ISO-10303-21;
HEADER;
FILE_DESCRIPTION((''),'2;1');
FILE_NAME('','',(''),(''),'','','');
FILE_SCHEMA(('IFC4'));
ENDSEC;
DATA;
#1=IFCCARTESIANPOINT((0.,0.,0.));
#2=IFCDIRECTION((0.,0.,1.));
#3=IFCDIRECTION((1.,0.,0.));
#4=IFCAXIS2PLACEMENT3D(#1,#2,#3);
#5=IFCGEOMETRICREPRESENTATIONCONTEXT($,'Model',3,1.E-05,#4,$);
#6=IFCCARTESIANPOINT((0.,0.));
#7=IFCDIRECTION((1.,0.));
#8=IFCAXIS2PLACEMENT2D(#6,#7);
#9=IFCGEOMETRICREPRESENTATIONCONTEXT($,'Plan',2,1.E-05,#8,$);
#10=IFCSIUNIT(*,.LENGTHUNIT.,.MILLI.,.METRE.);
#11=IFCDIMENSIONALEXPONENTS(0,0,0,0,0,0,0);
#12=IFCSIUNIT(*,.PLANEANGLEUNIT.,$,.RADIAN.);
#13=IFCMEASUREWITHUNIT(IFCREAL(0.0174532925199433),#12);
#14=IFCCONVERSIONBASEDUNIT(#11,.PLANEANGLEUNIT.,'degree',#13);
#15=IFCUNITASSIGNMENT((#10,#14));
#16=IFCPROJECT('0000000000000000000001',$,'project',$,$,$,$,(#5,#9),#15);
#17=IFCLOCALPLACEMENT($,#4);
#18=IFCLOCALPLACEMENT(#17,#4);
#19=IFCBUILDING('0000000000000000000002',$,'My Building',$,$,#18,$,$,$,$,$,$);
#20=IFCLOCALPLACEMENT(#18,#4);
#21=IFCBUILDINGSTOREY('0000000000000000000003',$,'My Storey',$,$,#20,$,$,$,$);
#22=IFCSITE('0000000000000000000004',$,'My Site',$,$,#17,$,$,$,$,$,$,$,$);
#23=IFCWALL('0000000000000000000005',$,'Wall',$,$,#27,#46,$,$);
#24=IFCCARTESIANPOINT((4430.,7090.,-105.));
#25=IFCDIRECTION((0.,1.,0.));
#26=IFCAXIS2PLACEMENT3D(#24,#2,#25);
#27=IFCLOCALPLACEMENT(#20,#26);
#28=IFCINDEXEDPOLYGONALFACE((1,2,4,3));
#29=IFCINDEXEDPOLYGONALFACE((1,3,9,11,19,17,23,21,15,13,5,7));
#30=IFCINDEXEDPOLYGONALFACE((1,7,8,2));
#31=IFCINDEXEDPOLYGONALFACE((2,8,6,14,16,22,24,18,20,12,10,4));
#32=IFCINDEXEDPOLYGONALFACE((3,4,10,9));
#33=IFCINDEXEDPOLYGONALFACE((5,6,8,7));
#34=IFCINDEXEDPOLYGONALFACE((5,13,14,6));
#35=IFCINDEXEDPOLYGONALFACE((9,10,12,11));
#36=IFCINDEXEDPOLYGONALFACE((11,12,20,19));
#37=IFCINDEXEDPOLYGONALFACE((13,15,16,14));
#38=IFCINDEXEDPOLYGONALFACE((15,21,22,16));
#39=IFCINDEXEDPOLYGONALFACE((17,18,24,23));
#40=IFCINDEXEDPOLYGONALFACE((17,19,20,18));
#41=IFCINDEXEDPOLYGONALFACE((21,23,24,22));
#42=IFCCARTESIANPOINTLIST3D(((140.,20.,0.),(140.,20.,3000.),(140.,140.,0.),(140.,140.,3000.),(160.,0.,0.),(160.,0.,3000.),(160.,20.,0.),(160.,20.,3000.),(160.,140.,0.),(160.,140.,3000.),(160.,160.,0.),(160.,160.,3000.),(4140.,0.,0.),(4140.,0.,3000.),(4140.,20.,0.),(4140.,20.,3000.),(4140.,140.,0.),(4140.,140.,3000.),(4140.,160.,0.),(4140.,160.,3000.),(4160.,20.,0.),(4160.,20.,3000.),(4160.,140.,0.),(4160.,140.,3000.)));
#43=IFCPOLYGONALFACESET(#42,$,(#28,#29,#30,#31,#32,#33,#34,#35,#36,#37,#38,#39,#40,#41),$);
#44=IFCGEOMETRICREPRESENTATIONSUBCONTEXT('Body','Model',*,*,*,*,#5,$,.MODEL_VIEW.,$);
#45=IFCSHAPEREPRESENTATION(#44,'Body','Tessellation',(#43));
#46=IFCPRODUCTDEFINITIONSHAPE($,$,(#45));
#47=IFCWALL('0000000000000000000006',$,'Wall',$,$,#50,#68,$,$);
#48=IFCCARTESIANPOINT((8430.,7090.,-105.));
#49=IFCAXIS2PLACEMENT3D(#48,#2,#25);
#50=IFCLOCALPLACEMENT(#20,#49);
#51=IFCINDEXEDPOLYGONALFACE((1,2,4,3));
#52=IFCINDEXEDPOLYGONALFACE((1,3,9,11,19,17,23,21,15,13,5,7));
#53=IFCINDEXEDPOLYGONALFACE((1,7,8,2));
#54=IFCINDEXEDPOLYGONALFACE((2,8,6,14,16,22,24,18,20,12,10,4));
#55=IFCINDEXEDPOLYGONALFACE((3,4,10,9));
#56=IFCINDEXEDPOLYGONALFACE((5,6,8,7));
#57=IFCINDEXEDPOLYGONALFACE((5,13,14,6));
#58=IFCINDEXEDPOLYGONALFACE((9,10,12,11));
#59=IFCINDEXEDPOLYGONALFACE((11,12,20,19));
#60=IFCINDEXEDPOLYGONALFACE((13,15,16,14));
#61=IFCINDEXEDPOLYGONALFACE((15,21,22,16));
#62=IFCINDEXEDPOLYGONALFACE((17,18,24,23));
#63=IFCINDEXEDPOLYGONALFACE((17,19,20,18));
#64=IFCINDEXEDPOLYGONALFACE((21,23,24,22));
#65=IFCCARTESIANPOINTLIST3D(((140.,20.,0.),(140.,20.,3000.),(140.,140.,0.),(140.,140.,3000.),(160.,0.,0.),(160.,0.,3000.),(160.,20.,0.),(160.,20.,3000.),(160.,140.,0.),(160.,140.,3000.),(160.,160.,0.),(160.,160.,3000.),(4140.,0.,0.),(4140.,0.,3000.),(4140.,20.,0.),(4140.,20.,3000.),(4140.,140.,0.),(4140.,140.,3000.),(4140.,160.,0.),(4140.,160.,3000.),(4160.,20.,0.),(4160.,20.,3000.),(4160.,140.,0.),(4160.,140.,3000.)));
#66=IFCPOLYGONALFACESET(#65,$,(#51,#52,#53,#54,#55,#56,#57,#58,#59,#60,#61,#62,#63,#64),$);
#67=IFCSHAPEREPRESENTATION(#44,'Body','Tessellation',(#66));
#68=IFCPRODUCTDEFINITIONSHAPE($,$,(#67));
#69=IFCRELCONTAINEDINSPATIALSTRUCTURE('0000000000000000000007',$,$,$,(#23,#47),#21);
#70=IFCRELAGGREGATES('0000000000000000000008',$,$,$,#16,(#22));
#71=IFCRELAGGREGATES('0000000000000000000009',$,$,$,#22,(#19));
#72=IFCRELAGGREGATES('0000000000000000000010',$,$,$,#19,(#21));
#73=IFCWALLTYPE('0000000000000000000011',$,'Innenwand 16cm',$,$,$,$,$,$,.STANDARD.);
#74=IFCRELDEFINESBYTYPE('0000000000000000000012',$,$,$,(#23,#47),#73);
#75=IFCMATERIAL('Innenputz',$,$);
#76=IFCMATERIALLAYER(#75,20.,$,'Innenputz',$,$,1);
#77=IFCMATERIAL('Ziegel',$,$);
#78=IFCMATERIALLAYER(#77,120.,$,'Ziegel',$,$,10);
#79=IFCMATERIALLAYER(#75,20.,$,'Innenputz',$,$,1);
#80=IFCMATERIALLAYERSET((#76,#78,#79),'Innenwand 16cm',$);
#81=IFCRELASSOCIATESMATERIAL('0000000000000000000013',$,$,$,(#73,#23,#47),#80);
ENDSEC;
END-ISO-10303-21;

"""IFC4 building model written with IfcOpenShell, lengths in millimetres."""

from ifc_helpers import new_model, entity, si_unit, converted_unit, frame, origin_with_axes, origin_2d_with_axis, place, context, subcontext, project, spatial, line, indexed_curve, outline, extrude, material, layer, layer_set, layer_usage, type_object, element, save


model = new_model("IFC4")

# Units and contexts
model_context = context("Model", 3, precision=1e-05, world=origin_with_axes())
plan_context = context("Plan", 2, precision=1e-05, world=origin_2d_with_axis())
body_context = subcontext(model_context, "Body", "Model", "MODEL_VIEW")
ifc_project = project(units=[si_unit("LENGTHUNIT", "METRE", prefix="MILLI"), converted_unit("PLANEANGLEUNIT", "degree", entity("IfcReal", 0.0174532925199433), si_unit("PLANEANGLEUNIT", "RADIAN"), dimensions=[0, 0, 0, 0, 0, 0, 0])], contexts=[model_context, plan_context])

# Site, building, storey
site_placement = place(None, origin_with_axes())
site = spatial("IfcSite", under=ifc_project, at=site_placement, Name="My Site")
building_placement = place(site_placement, origin_with_axes())
building = spatial("IfcBuilding", under=site, at=building_placement, Name="My Building")
storey_placement = place(building_placement, origin_with_axes())
storey = spatial("IfcBuildingStorey", under=building, at=storey_placement, Name="My Storey")

# Walls
ifc_material_1 = material(Name="Innenputz")
ifc_material_2 = material(Name="Ziegel")
ifc_layer_1 = layer(ifc_material_1, 20.0, Name="Innenputz", Priority=1)
ifc_layer_2 = layer(ifc_material_2, 120.0, Name="Ziegel", Priority=10)
ifc_layer_3 = layer(ifc_material_1, 20.0, Name="Innenputz", Priority=1)
ifc_layer_set_1 = layer_set([ifc_layer_1, ifc_layer_2, ifc_layer_3], Name="Innenwand 16cm")
wall_type_1 = type_object("IfcWallType", Name="Innenwand 16cm", PredefinedType="STANDARD", material=ifc_layer_set_1)
ifc_layer_usage_1 = layer_usage(ifc_layer_set_1, "AXIS2", "POSITIVE", 0.0)
wall_1_placement = place(storey_placement, frame((4430.0, 7090.0, -105.0), z_axis=(0.0, 0.0, 1.0), x_axis=(0.0, 1.0, 0.0)))
element("IfcWall", 1, at=wall_1_placement, inside=storey, type_object=wall_type_1, material=ifc_layer_usage_1, Name="Wall", context=body_context, shape_type="SweptSolid", body=[
    extrude(outline(indexed_curve([(160.0, 0.0), (160.0, 20.0), (140.0, 20.0), (140.0, 140.0), (160.0, 140.0), (160.0, 160.0), (4140.0, 160.0), (4140.0, 140.0), (4160.0, 140.0), (4160.0, 20.0), (4140.0, 20.0), (4140.0, 0.0)], segments=[line(1, 2, 3, 4, 5, 6, 7, 8, 9, 10, 11, 12, 1)])), origin_with_axes(), (0.0, 0.0, 1.0), 3000.0),
])
ifc_layer_usage_2 = layer_usage(ifc_layer_set_1, "AXIS2", "POSITIVE", 0.0)
wall_2_placement = place(storey_placement, frame((8430.0, 7090.0, -105.0), z_axis=(0.0, 0.0, 1.0), x_axis=(0.0, 1.0, 0.0)))
element("IfcWall", 2, at=wall_2_placement, inside=storey, type_object=wall_type_1, material=ifc_layer_usage_2, Name="Wall", context=body_context, shape_type="SweptSolid", body=[
    extrude(outline(indexed_curve([(160.0, 0.0), (160.0, 20.0), (140.0, 20.0), (140.0, 140.0), (160.0, 140.0), (160.0, 160.0), (4140.0, 160.0), (4140.0, 140.0), (4160.0, 140.0), (4160.0, 20.0), (4140.0, 20.0), (4140.0, 0.0)], segments=[line(1, 2, 3, 4, 5, 6, 7, 8, 9, 10, 11, 12, 1)])), origin_with_axes(), (0.0, 0.0, 1.0), 3000.0),
])

save(model, "model.ifc")
